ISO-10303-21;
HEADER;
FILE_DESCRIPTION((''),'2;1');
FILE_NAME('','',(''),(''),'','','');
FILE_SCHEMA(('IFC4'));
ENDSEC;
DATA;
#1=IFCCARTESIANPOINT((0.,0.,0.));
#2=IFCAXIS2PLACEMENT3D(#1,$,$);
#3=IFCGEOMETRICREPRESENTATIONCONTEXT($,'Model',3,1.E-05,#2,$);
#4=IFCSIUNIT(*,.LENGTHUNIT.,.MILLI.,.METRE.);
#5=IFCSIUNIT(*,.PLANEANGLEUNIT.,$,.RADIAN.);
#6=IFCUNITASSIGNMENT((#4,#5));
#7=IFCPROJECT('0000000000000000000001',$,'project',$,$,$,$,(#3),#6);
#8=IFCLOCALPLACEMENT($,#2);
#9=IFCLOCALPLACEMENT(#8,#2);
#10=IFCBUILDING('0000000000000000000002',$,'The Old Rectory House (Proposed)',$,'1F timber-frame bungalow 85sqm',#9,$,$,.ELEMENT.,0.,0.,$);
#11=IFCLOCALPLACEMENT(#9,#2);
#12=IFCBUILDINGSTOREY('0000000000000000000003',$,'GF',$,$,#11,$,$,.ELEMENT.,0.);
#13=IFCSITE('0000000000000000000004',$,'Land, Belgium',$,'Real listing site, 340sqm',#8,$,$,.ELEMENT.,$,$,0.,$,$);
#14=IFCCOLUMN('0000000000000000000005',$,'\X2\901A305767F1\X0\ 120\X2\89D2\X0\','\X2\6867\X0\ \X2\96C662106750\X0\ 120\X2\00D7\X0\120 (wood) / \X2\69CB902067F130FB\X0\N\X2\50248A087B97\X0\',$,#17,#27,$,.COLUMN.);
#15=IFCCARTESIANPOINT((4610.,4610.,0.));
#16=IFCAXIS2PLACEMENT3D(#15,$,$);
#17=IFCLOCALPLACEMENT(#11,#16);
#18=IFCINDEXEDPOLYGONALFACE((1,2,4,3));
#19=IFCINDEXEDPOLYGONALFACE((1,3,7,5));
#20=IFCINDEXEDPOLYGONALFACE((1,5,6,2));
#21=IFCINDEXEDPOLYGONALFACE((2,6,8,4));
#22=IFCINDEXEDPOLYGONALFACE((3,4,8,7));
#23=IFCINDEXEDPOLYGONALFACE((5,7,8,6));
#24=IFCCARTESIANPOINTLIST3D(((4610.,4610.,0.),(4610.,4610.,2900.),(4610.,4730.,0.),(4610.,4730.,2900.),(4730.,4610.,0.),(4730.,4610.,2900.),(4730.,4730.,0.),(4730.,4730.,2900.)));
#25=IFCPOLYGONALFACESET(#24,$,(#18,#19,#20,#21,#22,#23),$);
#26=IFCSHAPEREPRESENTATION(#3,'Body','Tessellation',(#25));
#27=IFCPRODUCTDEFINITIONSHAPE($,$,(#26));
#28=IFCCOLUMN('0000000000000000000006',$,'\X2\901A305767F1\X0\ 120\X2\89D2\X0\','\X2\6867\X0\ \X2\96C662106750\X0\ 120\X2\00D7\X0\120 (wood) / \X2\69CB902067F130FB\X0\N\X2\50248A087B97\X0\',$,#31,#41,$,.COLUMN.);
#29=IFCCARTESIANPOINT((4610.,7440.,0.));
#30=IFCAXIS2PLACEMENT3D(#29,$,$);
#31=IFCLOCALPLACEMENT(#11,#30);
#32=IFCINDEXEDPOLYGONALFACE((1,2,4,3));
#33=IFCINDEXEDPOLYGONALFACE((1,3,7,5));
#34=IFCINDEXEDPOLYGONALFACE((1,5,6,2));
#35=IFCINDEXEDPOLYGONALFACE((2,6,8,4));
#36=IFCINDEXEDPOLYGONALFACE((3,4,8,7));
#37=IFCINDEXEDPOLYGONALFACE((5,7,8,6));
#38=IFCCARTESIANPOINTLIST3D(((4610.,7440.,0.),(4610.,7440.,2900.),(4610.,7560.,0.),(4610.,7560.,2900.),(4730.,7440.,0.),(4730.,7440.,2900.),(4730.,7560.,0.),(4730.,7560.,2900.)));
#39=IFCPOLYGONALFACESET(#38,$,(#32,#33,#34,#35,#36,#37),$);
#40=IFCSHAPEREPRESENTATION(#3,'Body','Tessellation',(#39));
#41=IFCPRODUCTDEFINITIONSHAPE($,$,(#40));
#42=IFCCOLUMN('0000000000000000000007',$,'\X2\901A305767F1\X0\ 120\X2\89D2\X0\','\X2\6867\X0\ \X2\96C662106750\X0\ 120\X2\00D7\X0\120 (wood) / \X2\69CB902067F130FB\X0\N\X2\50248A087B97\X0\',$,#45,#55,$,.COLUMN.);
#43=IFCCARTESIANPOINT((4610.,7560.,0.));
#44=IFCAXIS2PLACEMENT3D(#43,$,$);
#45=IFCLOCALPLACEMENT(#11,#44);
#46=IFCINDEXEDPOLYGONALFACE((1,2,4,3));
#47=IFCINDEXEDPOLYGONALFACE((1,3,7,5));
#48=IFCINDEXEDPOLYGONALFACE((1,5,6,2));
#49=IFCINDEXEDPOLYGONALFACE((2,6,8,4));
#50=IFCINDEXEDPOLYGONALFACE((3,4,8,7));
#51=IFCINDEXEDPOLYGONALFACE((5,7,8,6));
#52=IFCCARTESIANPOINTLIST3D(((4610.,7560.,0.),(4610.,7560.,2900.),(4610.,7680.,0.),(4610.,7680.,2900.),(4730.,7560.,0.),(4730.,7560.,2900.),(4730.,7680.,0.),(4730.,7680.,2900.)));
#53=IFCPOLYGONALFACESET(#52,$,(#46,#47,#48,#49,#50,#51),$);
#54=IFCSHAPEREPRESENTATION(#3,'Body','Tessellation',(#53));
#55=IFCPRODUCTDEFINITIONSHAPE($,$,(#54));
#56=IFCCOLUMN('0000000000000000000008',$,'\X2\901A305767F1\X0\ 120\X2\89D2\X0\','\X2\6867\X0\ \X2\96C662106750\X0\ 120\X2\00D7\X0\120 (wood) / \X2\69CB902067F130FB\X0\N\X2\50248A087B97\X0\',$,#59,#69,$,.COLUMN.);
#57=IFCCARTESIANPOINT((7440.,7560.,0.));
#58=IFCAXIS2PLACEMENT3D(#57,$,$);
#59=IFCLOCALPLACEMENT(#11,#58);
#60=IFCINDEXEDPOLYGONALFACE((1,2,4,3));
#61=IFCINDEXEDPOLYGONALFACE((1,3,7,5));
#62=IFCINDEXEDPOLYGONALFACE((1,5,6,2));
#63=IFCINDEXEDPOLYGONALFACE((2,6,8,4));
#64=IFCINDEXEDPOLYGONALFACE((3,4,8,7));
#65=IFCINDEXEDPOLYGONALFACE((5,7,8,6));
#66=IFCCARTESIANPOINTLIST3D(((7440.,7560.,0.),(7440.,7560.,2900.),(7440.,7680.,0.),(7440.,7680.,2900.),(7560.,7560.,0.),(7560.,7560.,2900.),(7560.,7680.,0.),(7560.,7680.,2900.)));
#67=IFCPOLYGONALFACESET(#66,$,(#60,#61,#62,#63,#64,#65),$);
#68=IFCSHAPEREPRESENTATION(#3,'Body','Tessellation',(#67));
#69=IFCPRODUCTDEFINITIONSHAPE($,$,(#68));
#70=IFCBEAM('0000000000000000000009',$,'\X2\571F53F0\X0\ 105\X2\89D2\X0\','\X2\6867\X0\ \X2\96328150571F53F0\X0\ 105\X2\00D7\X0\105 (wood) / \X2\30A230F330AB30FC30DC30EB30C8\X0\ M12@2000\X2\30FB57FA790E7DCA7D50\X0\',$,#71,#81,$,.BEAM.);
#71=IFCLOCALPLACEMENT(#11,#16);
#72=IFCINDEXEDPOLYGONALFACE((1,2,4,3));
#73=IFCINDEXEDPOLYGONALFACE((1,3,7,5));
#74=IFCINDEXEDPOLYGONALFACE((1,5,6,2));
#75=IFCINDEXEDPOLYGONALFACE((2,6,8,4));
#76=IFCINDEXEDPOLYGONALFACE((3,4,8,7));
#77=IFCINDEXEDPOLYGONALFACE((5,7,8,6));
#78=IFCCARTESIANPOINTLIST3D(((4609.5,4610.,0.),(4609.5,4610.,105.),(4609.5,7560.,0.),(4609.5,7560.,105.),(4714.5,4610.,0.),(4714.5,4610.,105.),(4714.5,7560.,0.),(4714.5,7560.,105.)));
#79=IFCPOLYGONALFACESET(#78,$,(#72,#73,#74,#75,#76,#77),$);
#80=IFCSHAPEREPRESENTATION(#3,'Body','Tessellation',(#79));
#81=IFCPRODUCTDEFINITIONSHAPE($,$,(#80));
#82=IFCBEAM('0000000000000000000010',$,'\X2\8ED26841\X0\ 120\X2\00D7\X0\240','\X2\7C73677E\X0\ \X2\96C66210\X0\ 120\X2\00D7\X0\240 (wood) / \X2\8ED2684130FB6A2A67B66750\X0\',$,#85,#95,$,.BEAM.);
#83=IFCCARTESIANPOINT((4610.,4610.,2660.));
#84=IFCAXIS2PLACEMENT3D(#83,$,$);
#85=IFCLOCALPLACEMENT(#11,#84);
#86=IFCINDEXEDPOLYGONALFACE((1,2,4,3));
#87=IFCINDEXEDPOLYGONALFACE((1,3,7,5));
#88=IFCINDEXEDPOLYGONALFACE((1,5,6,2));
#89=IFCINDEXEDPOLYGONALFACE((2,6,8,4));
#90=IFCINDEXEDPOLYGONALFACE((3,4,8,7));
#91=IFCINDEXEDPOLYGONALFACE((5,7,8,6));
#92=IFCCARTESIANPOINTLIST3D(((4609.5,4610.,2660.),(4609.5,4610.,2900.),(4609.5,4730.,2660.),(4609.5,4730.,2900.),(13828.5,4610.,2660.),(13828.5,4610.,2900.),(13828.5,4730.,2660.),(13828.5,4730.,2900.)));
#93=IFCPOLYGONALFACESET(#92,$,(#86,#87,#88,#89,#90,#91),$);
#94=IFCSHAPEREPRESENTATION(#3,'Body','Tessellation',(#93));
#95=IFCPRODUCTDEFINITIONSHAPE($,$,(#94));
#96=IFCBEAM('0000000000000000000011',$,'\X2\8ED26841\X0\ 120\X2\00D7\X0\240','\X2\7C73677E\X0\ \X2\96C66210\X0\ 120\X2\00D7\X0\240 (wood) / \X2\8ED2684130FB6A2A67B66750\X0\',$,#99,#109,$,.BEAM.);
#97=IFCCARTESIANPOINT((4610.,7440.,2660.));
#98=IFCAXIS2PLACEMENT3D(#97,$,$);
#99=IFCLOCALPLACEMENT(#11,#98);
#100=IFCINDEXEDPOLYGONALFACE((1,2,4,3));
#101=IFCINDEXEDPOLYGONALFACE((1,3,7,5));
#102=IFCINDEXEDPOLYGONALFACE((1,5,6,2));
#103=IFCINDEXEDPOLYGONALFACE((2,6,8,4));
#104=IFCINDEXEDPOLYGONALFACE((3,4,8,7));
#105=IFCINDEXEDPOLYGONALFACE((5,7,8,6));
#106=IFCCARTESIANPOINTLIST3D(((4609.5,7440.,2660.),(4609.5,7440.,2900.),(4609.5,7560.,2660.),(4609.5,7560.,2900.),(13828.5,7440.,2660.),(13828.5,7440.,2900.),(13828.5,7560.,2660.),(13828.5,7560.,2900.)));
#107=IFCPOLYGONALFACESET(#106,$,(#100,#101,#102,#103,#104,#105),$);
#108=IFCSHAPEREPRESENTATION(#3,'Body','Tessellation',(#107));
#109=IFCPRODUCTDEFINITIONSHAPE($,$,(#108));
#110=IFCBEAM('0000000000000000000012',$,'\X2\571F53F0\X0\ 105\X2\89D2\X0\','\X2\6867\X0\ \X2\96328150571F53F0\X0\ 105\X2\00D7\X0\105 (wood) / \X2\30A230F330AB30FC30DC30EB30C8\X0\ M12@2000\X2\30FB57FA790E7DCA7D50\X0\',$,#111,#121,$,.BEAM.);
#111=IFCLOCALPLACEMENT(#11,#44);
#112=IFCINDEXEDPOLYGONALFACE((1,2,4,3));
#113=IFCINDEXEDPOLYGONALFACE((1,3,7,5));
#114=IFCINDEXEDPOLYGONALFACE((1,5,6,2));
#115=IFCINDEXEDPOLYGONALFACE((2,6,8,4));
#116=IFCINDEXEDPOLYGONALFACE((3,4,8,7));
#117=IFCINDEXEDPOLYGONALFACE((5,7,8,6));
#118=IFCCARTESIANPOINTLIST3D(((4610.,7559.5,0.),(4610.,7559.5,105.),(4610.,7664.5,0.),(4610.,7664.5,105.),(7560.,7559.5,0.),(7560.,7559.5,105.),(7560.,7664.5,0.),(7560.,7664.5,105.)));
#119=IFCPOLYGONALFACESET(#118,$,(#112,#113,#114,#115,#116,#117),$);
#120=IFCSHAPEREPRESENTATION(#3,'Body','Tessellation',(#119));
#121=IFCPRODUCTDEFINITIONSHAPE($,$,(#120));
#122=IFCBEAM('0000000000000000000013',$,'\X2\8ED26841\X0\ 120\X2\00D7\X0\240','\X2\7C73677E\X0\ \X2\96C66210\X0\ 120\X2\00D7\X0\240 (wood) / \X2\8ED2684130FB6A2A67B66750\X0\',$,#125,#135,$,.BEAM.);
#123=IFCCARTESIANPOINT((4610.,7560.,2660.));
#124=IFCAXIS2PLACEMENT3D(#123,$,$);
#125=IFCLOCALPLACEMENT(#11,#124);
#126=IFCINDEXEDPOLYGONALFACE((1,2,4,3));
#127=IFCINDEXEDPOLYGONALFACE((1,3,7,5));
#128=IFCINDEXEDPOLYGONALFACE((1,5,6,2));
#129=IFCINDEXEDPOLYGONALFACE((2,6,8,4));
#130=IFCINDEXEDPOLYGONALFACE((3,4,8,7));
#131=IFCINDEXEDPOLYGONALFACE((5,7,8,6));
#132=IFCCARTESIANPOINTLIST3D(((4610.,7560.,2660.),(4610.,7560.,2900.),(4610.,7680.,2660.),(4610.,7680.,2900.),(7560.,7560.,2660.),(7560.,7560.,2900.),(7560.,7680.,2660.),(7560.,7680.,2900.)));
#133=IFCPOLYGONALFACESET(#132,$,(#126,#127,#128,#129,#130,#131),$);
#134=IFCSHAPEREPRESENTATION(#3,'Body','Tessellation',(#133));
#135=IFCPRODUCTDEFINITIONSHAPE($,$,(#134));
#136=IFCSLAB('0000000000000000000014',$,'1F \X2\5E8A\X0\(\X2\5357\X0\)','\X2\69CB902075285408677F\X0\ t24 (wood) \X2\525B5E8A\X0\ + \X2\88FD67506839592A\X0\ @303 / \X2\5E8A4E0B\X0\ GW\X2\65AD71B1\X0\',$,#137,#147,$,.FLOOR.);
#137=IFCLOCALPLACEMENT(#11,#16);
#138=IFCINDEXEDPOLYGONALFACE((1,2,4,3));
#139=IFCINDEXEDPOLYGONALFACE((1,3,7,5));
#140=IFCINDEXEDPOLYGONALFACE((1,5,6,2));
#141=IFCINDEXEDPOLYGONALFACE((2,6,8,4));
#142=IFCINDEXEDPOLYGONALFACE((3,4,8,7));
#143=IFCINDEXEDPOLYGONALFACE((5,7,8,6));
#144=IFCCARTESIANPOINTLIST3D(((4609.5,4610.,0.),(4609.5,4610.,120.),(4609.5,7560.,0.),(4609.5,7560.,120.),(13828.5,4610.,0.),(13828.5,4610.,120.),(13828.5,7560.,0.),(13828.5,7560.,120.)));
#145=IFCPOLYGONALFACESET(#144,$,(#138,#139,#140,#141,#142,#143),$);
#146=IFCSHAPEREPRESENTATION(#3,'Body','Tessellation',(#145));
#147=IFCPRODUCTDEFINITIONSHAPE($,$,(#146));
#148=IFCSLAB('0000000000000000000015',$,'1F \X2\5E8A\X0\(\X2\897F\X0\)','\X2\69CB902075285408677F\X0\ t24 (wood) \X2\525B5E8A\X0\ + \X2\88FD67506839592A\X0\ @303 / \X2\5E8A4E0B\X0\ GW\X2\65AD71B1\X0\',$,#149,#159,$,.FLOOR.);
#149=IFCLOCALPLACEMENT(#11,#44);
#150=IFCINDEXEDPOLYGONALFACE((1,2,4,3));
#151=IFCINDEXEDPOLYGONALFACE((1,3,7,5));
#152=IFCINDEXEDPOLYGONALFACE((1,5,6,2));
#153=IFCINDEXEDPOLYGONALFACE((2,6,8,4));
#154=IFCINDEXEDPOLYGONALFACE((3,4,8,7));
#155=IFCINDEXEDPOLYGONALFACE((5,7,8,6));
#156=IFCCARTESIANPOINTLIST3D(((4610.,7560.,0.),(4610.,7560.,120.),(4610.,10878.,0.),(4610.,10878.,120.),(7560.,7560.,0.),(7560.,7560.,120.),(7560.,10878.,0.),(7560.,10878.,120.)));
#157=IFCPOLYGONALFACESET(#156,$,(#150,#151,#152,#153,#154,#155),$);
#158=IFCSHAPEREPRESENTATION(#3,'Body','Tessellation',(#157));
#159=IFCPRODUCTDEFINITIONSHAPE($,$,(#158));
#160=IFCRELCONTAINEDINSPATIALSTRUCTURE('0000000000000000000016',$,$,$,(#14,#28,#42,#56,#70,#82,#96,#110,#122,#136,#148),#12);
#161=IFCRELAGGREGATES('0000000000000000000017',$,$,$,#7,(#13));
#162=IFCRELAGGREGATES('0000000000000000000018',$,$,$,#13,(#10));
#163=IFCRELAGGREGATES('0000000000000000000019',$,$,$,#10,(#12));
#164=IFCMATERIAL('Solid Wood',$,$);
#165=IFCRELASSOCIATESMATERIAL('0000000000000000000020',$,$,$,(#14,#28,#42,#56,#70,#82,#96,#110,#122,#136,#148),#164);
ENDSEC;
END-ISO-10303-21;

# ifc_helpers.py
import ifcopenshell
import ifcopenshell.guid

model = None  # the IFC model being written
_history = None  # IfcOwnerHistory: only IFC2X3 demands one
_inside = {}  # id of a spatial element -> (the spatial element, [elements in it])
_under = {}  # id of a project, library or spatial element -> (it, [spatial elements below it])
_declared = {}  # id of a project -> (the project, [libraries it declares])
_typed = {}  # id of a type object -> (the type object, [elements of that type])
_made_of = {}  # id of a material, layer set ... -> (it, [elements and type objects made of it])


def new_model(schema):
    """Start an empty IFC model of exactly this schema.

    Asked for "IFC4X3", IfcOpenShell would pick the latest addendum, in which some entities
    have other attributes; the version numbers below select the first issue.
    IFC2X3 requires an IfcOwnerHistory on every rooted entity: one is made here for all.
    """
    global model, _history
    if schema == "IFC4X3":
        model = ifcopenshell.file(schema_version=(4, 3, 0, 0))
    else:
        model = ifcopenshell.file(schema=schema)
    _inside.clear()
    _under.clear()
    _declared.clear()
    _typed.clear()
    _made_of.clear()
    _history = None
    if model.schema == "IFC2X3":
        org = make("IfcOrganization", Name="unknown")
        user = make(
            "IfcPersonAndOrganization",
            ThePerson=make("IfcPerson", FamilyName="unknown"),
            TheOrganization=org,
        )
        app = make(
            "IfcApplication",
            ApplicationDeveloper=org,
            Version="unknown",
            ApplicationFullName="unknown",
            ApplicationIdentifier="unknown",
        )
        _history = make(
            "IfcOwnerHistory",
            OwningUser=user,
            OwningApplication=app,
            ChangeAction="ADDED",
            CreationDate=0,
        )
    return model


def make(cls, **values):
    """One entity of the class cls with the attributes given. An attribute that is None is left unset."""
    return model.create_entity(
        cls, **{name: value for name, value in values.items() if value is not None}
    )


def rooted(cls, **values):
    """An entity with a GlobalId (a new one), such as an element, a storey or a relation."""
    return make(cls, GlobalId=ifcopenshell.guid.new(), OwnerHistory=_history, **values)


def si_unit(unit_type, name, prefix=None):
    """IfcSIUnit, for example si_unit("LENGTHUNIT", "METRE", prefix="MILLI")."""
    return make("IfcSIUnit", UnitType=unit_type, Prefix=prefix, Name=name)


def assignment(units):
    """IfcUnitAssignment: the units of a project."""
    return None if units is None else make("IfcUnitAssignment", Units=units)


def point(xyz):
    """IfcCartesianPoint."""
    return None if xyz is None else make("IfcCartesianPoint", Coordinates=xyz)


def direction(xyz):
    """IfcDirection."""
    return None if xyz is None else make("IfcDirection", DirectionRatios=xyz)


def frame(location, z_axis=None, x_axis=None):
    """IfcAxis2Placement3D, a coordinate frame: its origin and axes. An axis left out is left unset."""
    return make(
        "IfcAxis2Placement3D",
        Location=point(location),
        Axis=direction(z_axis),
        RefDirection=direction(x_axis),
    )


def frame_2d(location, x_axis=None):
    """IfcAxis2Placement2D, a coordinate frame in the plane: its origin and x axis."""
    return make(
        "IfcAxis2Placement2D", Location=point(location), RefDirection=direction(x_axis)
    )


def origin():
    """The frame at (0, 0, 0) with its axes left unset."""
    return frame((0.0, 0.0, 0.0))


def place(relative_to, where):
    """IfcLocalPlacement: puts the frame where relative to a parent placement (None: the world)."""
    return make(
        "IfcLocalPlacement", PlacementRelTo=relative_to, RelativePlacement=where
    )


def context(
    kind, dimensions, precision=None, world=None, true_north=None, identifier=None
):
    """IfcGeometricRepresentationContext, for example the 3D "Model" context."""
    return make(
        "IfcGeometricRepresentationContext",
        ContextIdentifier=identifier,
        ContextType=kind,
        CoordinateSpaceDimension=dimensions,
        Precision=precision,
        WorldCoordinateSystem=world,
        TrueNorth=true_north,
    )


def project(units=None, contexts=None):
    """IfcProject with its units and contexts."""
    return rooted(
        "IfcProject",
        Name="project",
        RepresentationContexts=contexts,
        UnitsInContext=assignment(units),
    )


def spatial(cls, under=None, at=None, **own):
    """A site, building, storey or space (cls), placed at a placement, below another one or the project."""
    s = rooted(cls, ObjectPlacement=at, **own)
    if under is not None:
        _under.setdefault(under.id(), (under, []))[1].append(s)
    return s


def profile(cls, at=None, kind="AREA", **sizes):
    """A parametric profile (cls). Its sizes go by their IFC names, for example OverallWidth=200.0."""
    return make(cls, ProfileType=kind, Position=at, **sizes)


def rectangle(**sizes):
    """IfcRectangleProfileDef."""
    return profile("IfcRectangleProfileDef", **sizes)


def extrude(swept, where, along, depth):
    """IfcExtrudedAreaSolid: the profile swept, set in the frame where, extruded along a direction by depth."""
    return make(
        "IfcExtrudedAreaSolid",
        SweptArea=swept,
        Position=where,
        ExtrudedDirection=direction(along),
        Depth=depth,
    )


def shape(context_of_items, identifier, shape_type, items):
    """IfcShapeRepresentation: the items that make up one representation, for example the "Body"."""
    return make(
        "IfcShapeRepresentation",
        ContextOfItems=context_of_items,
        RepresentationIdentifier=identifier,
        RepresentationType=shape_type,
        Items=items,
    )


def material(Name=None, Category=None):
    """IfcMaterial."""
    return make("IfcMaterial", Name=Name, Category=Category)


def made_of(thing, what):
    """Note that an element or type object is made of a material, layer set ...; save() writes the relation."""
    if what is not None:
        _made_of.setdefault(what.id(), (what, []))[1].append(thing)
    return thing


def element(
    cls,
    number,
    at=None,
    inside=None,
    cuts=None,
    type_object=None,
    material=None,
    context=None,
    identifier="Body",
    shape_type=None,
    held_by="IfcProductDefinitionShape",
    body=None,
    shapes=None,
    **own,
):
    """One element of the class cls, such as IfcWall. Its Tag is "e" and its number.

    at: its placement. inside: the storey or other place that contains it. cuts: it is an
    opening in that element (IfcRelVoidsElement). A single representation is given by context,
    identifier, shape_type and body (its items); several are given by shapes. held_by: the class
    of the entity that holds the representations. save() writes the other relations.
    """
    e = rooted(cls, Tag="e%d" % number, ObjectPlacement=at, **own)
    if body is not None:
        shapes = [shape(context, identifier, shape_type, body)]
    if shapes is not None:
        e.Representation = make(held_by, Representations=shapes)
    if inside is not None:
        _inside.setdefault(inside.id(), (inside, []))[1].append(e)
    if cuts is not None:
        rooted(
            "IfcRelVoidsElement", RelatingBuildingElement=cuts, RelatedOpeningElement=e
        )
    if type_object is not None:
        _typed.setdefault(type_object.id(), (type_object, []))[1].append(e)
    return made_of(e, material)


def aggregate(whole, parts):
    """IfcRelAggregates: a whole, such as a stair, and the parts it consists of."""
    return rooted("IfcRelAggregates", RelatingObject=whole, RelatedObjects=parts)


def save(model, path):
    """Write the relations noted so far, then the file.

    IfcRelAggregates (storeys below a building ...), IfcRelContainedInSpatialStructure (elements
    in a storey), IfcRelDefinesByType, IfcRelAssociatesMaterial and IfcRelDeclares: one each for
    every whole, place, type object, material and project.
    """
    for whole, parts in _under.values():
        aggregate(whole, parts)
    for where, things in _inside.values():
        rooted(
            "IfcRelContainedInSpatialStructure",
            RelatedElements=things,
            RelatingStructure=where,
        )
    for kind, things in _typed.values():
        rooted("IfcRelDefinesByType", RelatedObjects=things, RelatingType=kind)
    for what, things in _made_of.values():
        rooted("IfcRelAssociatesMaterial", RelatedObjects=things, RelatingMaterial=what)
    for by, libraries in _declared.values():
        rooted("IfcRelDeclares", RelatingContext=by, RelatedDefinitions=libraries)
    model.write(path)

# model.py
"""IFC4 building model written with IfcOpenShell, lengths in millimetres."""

from ifc_helpers import new_model, si_unit, frame, frame_2d, origin, place, context, project, spatial, rectangle, extrude, material, element, save


model = new_model("IFC4")

# Units and contexts
model_context = context("Model", 3, precision=1e-05, world=origin())
ifc_project = project(units=[si_unit("LENGTHUNIT", "METRE", prefix="MILLI"), si_unit("PLANEANGLEUNIT", "RADIAN")], contexts=[model_context])

# Site, building, storey
site_placement = place(None, origin())
site = spatial("IfcSite", under=ifc_project, at=site_placement, Name="Land, Belgium", ObjectType="Real listing site, 340sqm", CompositionType="ELEMENT", RefElevation=0.0)
building_placement = place(site_placement, origin())
building = spatial("IfcBuilding", under=site, at=building_placement, Name="The Old Rectory House (Proposed)", ObjectType="1F timber-frame bungalow 85sqm", CompositionType="ELEMENT", ElevationOfRefHeight=0.0, ElevationOfTerrain=0.0)
storey_placement = place(building_placement, origin())
storey = spatial("IfcBuildingStorey", under=building, at=storey_placement, Name="GF", CompositionType="ELEMENT", Elevation=0.0)

# Columns
ifc_material_1 = material(Name="Solid Wood")
column_1_placement = place(storey_placement, frame((4610.0, 4610.0, 0.0)))
element("IfcColumn", 1, at=column_1_placement, inside=storey, material=ifc_material_1, Name="通し柱 120角", Description="桧 集成材 120×120 (wood) / 構造柱・N値計算", PredefinedType="COLUMN", context=model_context, shape_type="SweptSolid", body=[
    extrude(rectangle(XDim=120.0, YDim=120.0, at=frame_2d((60.0, 60.0))), frame((4610.0, 4610.0, 0.0)), (0.0, 0.0, 1.0), 2900.0),
])
column_2_placement = place(storey_placement, frame((4610.0, 7440.0, 0.0)))
element("IfcColumn", 2, at=column_2_placement, inside=storey, material=ifc_material_1, Name="通し柱 120角", Description="桧 集成材 120×120 (wood) / 構造柱・N値計算", PredefinedType="COLUMN", context=model_context, shape_type="SweptSolid", body=[
    extrude(rectangle(XDim=120.0, YDim=120.0, at=frame_2d((60.0, 60.0))), frame((4610.0, 7440.0, 0.0)), (0.0, 0.0, 1.0), 2900.0),
])
column_3_placement = place(storey_placement, frame((4610.0, 7560.0, 0.0)))
element("IfcColumn", 3, at=column_3_placement, inside=storey, material=ifc_material_1, Name="通し柱 120角", Description="桧 集成材 120×120 (wood) / 構造柱・N値計算", PredefinedType="COLUMN", context=model_context, shape_type="SweptSolid", body=[
    extrude(rectangle(XDim=120.0, YDim=120.0, at=frame_2d((60.0, 60.0))), frame((4610.0, 7560.0, 0.0)), (0.0, 0.0, 1.0), 2900.0),
])
column_4_placement = place(storey_placement, frame((7440.0, 7560.0, 0.0)))
element("IfcColumn", 4, at=column_4_placement, inside=storey, material=ifc_material_1, Name="通し柱 120角", Description="桧 集成材 120×120 (wood) / 構造柱・N値計算", PredefinedType="COLUMN", context=model_context, shape_type="SweptSolid", body=[
    extrude(rectangle(XDim=120.0, YDim=120.0, at=frame_2d((60.0, 60.0))), frame((7440.0, 7560.0, 0.0)), (0.0, 0.0, 1.0), 2900.0),
])

# Beams
beam_1_placement = place(storey_placement, frame((4610.0, 4610.0, 0.0)))
element("IfcBeam", 5, at=beam_1_placement, inside=storey, material=ifc_material_1, Name="土台 105角", Description="桧 防腐土台 105×105 (wood) / アンカーボルト M12@2000・基礎緊結", PredefinedType="BEAM", context=model_context, shape_type="SweptSolid", body=[
    extrude(rectangle(XDim=105.0, YDim=2950.0, at=frame_2d((52.0, 1475.0))), frame((4610.0, 4610.0, 0.0)), (0.0, 0.0, 1.0), 105.0),
])
beam_2_placement = place(storey_placement, frame((4610.0, 4610.0, 2660.0)))
element("IfcBeam", 6, at=beam_2_placement, inside=storey, material=ifc_material_1, Name="軒桁 120×240", Description="米松 集成 120×240 (wood) / 軒桁・横架材", PredefinedType="BEAM", context=model_context, shape_type="SweptSolid", body=[
    extrude(rectangle(XDim=9219.0, YDim=120.0, at=frame_2d((4609.0, 60.0))), frame((4610.0, 4610.0, 2660.0)), (0.0, 0.0, 1.0), 240.0),
])
beam_3_placement = place(storey_placement, frame((4610.0, 7440.0, 2660.0)))
element("IfcBeam", 7, at=beam_3_placement, inside=storey, material=ifc_material_1, Name="軒桁 120×240", Description="米松 集成 120×240 (wood) / 軒桁・横架材", PredefinedType="BEAM", context=model_context, shape_type="SweptSolid", body=[
    extrude(rectangle(XDim=9219.0, YDim=120.0, at=frame_2d((4609.0, 60.0))), frame((4610.0, 7440.0, 2660.0)), (0.0, 0.0, 1.0), 240.0),
])
beam_4_placement = place(storey_placement, frame((4610.0, 7560.0, 0.0)))
element("IfcBeam", 8, at=beam_4_placement, inside=storey, material=ifc_material_1, Name="土台 105角", Description="桧 防腐土台 105×105 (wood) / アンカーボルト M12@2000・基礎緊結", PredefinedType="BEAM", context=model_context, shape_type="SweptSolid", body=[
    extrude(rectangle(XDim=2950.0, YDim=105.0, at=frame_2d((1475.0, 52.0))), frame((4610.0, 7560.0, 0.0)), (0.0, 0.0, 1.0), 105.0),
])
beam_5_placement = place(storey_placement, frame((4610.0, 7560.0, 2660.0)))
element("IfcBeam", 9, at=beam_5_placement, inside=storey, material=ifc_material_1, Name="軒桁 120×240", Description="米松 集成 120×240 (wood) / 軒桁・横架材", PredefinedType="BEAM", context=model_context, shape_type="SweptSolid", body=[
    extrude(rectangle(XDim=2950.0, YDim=120.0, at=frame_2d((1475.0, 60.0))), frame((4610.0, 7560.0, 2660.0)), (0.0, 0.0, 1.0), 240.0),
])

# Slabs
slab_1_placement = place(storey_placement, frame((4610.0, 4610.0, 0.0)))
element("IfcSlab", 10, at=slab_1_placement, inside=storey, material=ifc_material_1, Name="1F 床(南)", Description="構造用合板 t24 (wood) 剛床 + 製材根太 @303 / 床下 GW断熱", PredefinedType="FLOOR", context=model_context, shape_type="SweptSolid", body=[
    extrude(rectangle(XDim=9219.0, YDim=2950.0, at=frame_2d((4609.0, 1475.0))), frame((4610.0, 4610.0, 0.0)), (0.0, 0.0, 1.0), 120.0),
])
slab_2_placement = place(storey_placement, frame((4610.0, 7560.0, 0.0)))
element("IfcSlab", 11, at=slab_2_placement, inside=storey, material=ifc_material_1, Name="1F 床(西)", Description="構造用合板 t24 (wood) 剛床 + 製材根太 @303 / 床下 GW断熱", PredefinedType="FLOOR", context=model_context, shape_type="SweptSolid", body=[
    extrude(rectangle(XDim=2950.0, YDim=3318.0, at=frame_2d((1475.0, 1659.0))), frame((4610.0, 7560.0, 0.0)), (0.0, 0.0, 1.0), 120.0),
])

save(model, "model.ifc")
